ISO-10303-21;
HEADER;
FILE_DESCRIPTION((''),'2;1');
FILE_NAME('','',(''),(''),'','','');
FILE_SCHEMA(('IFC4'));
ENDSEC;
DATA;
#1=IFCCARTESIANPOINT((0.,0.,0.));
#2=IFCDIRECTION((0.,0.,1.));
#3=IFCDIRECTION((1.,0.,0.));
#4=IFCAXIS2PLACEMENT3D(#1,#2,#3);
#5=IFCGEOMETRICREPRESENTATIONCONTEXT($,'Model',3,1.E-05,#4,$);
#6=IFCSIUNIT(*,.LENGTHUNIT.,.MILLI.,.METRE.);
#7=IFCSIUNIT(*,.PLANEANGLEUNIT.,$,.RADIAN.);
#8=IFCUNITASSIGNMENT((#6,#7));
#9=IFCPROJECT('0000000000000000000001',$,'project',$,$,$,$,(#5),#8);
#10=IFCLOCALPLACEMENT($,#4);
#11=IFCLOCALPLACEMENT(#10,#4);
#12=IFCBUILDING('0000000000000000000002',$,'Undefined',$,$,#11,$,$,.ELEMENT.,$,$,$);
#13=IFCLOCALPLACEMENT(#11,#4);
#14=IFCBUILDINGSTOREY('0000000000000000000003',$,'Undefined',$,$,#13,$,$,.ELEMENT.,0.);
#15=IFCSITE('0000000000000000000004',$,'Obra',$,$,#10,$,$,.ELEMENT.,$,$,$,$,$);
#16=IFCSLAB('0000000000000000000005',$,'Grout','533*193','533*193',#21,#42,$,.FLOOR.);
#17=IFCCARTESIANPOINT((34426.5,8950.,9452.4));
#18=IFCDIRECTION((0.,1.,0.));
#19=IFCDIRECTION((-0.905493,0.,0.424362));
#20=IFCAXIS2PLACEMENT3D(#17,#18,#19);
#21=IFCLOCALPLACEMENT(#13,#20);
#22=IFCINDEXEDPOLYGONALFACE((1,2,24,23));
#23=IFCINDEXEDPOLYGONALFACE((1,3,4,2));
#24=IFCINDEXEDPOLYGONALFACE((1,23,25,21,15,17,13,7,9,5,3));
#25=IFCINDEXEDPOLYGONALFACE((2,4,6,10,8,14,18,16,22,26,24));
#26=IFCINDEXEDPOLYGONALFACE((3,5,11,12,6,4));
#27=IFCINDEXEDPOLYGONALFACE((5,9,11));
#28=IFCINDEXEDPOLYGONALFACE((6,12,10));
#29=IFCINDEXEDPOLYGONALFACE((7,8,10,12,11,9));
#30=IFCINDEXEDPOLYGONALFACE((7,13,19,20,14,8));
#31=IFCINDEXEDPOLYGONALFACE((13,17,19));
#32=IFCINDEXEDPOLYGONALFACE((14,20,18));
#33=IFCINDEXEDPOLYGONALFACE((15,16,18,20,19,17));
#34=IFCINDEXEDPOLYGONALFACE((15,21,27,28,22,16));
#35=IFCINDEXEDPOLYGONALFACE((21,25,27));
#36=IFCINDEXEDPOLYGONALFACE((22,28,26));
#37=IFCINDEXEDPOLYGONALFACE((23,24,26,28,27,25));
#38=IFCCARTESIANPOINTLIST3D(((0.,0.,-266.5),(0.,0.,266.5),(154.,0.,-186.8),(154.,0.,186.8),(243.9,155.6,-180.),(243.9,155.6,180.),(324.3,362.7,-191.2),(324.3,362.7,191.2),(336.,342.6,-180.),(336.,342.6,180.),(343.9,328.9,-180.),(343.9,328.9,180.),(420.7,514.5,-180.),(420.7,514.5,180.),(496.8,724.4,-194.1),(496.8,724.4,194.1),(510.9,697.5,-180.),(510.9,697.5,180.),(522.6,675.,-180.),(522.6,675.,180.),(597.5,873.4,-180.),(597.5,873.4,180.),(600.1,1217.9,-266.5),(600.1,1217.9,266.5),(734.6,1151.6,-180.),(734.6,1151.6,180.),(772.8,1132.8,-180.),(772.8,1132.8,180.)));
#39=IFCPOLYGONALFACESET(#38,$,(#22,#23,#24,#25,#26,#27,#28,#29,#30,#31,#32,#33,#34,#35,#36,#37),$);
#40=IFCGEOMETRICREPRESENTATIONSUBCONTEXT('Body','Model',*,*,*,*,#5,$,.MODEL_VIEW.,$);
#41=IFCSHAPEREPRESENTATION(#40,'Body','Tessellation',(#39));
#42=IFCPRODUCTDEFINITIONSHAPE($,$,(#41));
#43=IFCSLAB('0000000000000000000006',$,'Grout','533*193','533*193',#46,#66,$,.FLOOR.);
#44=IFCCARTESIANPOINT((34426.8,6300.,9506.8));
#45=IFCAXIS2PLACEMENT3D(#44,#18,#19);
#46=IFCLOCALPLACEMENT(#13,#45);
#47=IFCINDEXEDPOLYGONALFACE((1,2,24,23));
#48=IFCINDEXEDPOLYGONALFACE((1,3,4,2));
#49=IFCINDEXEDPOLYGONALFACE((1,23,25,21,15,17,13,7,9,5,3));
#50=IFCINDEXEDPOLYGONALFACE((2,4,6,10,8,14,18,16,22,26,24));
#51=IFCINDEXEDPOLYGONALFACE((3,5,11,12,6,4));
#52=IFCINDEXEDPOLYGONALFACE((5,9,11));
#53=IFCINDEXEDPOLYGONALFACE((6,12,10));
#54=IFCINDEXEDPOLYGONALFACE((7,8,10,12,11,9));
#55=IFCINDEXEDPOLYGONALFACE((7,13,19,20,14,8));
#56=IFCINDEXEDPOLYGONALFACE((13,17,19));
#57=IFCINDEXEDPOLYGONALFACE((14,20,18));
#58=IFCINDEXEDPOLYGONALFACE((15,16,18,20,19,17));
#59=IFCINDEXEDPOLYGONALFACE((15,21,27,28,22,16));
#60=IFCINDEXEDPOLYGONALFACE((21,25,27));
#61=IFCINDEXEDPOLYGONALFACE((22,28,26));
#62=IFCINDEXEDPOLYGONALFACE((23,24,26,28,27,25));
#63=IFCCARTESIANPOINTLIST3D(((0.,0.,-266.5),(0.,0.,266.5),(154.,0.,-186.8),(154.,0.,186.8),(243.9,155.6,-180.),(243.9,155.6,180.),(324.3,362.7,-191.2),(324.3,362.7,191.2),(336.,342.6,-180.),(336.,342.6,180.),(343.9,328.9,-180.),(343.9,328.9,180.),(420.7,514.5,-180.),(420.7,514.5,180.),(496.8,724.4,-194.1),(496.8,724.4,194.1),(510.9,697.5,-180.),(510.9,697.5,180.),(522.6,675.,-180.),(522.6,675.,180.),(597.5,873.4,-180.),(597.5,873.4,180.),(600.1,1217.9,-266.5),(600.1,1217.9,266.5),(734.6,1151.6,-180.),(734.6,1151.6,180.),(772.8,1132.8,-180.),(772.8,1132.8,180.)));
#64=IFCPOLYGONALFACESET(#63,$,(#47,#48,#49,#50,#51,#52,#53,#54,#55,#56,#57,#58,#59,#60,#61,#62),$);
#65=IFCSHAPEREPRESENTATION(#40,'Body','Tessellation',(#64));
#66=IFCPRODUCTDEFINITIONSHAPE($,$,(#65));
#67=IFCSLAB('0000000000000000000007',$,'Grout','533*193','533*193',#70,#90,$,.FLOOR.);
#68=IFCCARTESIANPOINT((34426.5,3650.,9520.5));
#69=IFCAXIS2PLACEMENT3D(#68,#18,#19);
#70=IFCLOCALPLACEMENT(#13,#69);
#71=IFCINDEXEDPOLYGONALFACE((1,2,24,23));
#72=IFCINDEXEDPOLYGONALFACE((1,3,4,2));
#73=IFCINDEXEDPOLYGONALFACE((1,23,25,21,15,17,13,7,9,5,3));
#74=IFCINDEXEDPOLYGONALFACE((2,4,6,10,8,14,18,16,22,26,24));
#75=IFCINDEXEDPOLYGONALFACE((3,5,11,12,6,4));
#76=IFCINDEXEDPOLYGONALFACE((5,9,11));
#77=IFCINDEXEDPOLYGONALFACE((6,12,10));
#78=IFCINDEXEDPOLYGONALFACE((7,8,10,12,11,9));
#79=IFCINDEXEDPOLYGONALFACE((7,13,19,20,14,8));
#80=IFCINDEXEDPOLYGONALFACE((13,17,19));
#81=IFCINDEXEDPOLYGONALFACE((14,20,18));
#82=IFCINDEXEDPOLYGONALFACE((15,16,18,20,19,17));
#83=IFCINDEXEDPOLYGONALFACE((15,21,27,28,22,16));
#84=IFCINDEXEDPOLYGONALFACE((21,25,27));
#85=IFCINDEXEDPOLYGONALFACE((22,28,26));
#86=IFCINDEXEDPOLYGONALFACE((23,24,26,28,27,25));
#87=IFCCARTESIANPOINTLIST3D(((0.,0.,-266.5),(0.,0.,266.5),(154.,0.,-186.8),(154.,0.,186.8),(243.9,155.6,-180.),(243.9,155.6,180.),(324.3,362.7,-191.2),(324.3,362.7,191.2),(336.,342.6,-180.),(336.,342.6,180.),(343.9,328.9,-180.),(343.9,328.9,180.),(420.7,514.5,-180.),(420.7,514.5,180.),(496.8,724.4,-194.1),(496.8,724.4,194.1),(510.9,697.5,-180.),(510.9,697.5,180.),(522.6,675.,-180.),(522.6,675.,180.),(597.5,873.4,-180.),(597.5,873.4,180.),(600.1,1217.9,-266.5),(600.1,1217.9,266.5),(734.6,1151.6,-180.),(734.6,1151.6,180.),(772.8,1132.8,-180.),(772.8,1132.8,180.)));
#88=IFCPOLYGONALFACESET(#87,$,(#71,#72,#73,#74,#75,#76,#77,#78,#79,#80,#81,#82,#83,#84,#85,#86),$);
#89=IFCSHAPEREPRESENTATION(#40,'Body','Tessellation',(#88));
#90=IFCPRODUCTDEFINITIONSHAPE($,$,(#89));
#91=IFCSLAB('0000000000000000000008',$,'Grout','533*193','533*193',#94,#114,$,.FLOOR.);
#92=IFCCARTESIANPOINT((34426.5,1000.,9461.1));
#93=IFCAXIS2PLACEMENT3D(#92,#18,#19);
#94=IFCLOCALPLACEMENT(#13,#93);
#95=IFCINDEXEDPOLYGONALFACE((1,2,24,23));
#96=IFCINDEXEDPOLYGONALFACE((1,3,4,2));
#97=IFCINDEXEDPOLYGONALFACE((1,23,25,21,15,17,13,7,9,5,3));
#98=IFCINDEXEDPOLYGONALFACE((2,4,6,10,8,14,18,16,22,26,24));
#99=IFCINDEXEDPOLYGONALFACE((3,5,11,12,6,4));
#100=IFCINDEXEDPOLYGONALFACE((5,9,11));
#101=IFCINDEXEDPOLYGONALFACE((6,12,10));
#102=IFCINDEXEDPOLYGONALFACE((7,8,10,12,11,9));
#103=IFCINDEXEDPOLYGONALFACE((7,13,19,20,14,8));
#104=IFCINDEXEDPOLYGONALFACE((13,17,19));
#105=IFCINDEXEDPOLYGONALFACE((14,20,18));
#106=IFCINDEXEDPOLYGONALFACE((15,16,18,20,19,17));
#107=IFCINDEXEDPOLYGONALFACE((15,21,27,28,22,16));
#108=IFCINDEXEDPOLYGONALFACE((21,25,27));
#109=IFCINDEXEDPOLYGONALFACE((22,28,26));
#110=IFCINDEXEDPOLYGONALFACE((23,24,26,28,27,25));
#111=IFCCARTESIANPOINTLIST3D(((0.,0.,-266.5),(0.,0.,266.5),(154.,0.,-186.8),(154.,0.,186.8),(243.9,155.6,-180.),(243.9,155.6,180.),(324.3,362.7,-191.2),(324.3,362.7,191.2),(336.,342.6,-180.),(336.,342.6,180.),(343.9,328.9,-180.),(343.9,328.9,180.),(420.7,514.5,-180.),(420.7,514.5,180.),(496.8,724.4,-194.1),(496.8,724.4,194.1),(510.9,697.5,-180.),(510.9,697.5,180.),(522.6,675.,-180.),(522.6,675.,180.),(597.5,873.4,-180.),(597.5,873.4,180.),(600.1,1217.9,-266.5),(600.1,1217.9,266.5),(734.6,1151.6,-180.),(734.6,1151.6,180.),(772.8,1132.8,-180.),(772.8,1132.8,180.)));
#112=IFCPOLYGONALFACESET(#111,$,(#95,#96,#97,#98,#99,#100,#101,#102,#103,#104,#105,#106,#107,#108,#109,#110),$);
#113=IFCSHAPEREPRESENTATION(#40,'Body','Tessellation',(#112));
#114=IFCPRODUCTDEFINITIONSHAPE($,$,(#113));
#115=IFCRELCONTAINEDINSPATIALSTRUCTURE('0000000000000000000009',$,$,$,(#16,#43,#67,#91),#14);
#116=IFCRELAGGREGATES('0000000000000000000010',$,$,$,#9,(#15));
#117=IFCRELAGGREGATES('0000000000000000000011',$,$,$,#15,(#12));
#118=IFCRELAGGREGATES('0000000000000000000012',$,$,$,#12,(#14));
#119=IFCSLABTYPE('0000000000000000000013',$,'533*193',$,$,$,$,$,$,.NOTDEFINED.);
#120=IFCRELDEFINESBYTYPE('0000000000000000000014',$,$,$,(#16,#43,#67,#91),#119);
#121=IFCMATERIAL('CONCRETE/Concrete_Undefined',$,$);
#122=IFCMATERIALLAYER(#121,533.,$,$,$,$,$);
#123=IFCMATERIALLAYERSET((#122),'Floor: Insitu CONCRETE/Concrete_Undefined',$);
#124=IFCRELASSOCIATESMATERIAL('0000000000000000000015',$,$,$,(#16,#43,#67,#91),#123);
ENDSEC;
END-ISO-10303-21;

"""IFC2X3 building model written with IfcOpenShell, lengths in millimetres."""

from ifc_helpers import new_model, si_unit, frame, origin_with_axes, place, context, subcontext, project, spatial, polyline, outline, extrude, boolean, material, layer, layer_set, layer_usage, type_object, element, save


model = new_model("IFC2X3")

# Units and contexts
model_context = context("Model", 3, precision=1e-05, world=origin_with_axes())
body_context = subcontext(model_context, "Body", "Model", "MODEL_VIEW")
ifc_project = project(units=[si_unit("LENGTHUNIT", "METRE", prefix="MILLI"), si_unit("PLANEANGLEUNIT", "RADIAN")], contexts=[model_context])

# Site, building, storey
site_placement = place(None, origin_with_axes())
site = spatial("IfcSite", under=ifc_project, at=site_placement, Name="Obra", CompositionType="ELEMENT")
building_placement = place(site_placement, origin_with_axes())
building = spatial("IfcBuilding", under=site, at=building_placement, Name="Undefined", CompositionType="ELEMENT")
storey_placement = place(building_placement, origin_with_axes())
storey = spatial("IfcBuildingStorey", under=building, at=storey_placement, Name="Undefined", CompositionType="ELEMENT", Elevation=0.0)

# Slabs
ifc_material_1 = material(Name="CONCRETE/Concrete_Undefined")
ifc_layer_1 = layer(ifc_material_1, 533.0)
ifc_layer_set_1 = layer_set([ifc_layer_1], Name="Floor: Insitu CONCRETE/Concrete_Undefined")
ifc_layer_usage_1 = layer_usage(ifc_layer_set_1, "AXIS3", "POSITIVE", -266.5)
slab_type_1 = type_object("IfcSlabType", Name="533*193", PredefinedType="NOTDEFINED")
slab_1_placement = place(storey_placement, frame((34426.5, 8950.0, 9452.4), z_axis=(0.0, 1.0, 0.0), x_axis=(-0.905493, 0.0, 0.424362)))
element("IfcSlab", 1, at=slab_1_placement, inside=storey, type_object=slab_type_1, material=ifc_layer_usage_1, Name="Grout", Description="533*193", ObjectType="533*193", PredefinedType="FLOOR", context=body_context, shape_type="CSG", body=[
    boolean("DIFFERENCE", boolean("DIFFERENCE", extrude(outline(polyline([(0.0, 0.0), (154.0, 0.0), (343.9, 328.9), (324.3, 362.7), (522.6, 675.0), (496.8, 724.4), (772.8, 1132.8), (600.1, 1217.9), (0.0, 0.0)])), frame((0.0, 0.0, -266.5), z_axis=(0.0, 0.0, 1.0), x_axis=(1.0, 0.0, 0.0)), (0.0, 0.0, 1.0), 533.0), extrude(outline(polyline([(0.0, 0.0), (173.2, 0.0), (210.0, 21.3), (166.8, 96.2), (0.0, 0.0)])), frame((611.1, 1240.3, 266.5), z_axis=(-0.44198, -0.897025, 0.0), x_axis=(0.777076, -0.382879, -0.499556)), (0.0, 0.0, 1.0), 1400.0)), extrude(outline(polyline([(0.0, 0.0), (173.2, 0.0), (210.0, 21.3), (166.8, 96.2), (0.0, 0.0)])), frame((-7.7, -15.5, -266.5), z_axis=(0.44198, 0.897025, 0.0), x_axis=(0.777076, -0.382879, 0.499556)), (0.0, 0.0, 1.0), 1400.0)),
])
ifc_layer_usage_2 = layer_usage(ifc_layer_set_1, "AXIS3", "POSITIVE", -266.5)
slab_2_placement = place(storey_placement, frame((34426.8, 6300.0, 9506.8), z_axis=(0.0, 1.0, 0.0), x_axis=(-0.905493, 0.0, 0.424362)))
element("IfcSlab", 2, at=slab_2_placement, inside=storey, type_object=slab_type_1, material=ifc_layer_usage_2, Name="Grout", Description="533*193", ObjectType="533*193", PredefinedType="FLOOR", context=body_context, shape_type="CSG", body=[
    boolean("DIFFERENCE", boolean("DIFFERENCE", extrude(outline(polyline([(0.0, 0.0), (154.0, 0.0), (343.9, 328.9), (324.3, 362.7), (522.6, 675.0), (496.8, 724.4), (772.8, 1132.8), (600.1, 1217.9), (0.0, 0.0)])), frame((0.0, 0.0, -266.5), z_axis=(0.0, 0.0, 1.0), x_axis=(1.0, 0.0, 0.0)), (0.0, 0.0, 1.0), 533.0), extrude(outline(polyline([(0.0, 0.0), (173.2, 0.0), (210.0, 21.3), (166.8, 96.2), (0.0, 0.0)])), frame((611.1, 1240.3, 266.5), z_axis=(-0.44198, -0.897025, 0.0), x_axis=(0.777076, -0.382879, -0.499556)), (0.0, 0.0, 1.0), 1400.0)), extrude(outline(polyline([(0.0, 0.0), (173.2, 0.0), (210.0, 21.3), (166.8, 96.2), (0.0, 0.0)])), frame((-7.7, -15.5, -266.5), z_axis=(0.44198, 0.897025, 0.0), x_axis=(0.777076, -0.382879, 0.499556)), (0.0, 0.0, 1.0), 1400.0)),
])
ifc_layer_usage_3 = layer_usage(ifc_layer_set_1, "AXIS3", "POSITIVE", -266.5)
slab_3_placement = place(storey_placement, frame((34426.5, 3650.0, 9520.5), z_axis=(0.0, 1.0, 0.0), x_axis=(-0.905493, 0.0, 0.424362)))
element("IfcSlab", 3, at=slab_3_placement, inside=storey, type_object=slab_type_1, material=ifc_layer_usage_3, Name="Grout", Description="533*193", ObjectType="533*193", PredefinedType="FLOOR", context=body_context, shape_type="CSG", body=[
    boolean("DIFFERENCE", boolean("DIFFERENCE", extrude(outline(polyline([(0.0, 0.0), (154.0, 0.0), (343.9, 328.9), (324.3, 362.7), (522.6, 675.0), (496.8, 724.4), (772.8, 1132.8), (600.1, 1217.9), (0.0, 0.0)])), frame((0.0, 0.0, -266.5), z_axis=(0.0, 0.0, 1.0), x_axis=(1.0, 0.0, 0.0)), (0.0, 0.0, 1.0), 533.0), extrude(outline(polyline([(0.0, 0.0), (173.2, 0.0), (210.0, 21.3), (166.8, 96.2), (0.0, 0.0)])), frame((611.1, 1240.3, 266.5), z_axis=(-0.44198, -0.897025, 0.0), x_axis=(0.777076, -0.382879, -0.499556)), (0.0, 0.0, 1.0), 1400.0)), extrude(outline(polyline([(0.0, 0.0), (173.2, 0.0), (210.0, 21.3), (166.8, 96.2), (0.0, 0.0)])), frame((-7.7, -15.5, -266.5), z_axis=(0.44198, 0.897025, 0.0), x_axis=(0.777076, -0.382879, 0.499556)), (0.0, 0.0, 1.0), 1400.0)),
])
ifc_layer_usage_4 = layer_usage(ifc_layer_set_1, "AXIS3", "POSITIVE", -266.5)
slab_4_placement = place(storey_placement, frame((34426.5, 1000.0, 9461.1), z_axis=(0.0, 1.0, 0.0), x_axis=(-0.905493, 0.0, 0.424362)))
element("IfcSlab", 4, at=slab_4_placement, inside=storey, type_object=slab_type_1, material=ifc_layer_usage_4, Name="Grout", Description="533*193", ObjectType="533*193", PredefinedType="FLOOR", context=body_context, shape_type="CSG", body=[
    boolean("DIFFERENCE", boolean("DIFFERENCE", extrude(outline(polyline([(0.0, 0.0), (154.0, 0.0), (343.9, 328.9), (324.3, 362.7), (522.6, 675.0), (496.8, 724.4), (772.8, 1132.8), (600.1, 1217.9), (0.0, 0.0)])), frame((0.0, 0.0, -266.5), z_axis=(0.0, 0.0, 1.0), x_axis=(1.0, 0.0, 0.0)), (0.0, 0.0, 1.0), 533.0), extrude(outline(polyline([(0.0, 0.0), (173.2, 0.0), (210.0, 21.3), (166.8, 96.2), (0.0, 0.0)])), frame((611.1, 1240.3, 266.5), z_axis=(-0.44198, -0.897025, 0.0), x_axis=(0.777076, -0.382879, -0.499556)), (0.0, 0.0, 1.0), 1400.0)), extrude(outline(polyline([(0.0, 0.0), (173.2, 0.0), (210.0, 21.3), (166.8, 96.2), (0.0, 0.0)])), frame((-7.7, -15.5, -266.5), z_axis=(0.44198, 0.897025, 0.0), x_axis=(0.777076, -0.382879, 0.499556)), (0.0, 0.0, 1.0), 1400.0)),
])

save(model, "model.ifc")
